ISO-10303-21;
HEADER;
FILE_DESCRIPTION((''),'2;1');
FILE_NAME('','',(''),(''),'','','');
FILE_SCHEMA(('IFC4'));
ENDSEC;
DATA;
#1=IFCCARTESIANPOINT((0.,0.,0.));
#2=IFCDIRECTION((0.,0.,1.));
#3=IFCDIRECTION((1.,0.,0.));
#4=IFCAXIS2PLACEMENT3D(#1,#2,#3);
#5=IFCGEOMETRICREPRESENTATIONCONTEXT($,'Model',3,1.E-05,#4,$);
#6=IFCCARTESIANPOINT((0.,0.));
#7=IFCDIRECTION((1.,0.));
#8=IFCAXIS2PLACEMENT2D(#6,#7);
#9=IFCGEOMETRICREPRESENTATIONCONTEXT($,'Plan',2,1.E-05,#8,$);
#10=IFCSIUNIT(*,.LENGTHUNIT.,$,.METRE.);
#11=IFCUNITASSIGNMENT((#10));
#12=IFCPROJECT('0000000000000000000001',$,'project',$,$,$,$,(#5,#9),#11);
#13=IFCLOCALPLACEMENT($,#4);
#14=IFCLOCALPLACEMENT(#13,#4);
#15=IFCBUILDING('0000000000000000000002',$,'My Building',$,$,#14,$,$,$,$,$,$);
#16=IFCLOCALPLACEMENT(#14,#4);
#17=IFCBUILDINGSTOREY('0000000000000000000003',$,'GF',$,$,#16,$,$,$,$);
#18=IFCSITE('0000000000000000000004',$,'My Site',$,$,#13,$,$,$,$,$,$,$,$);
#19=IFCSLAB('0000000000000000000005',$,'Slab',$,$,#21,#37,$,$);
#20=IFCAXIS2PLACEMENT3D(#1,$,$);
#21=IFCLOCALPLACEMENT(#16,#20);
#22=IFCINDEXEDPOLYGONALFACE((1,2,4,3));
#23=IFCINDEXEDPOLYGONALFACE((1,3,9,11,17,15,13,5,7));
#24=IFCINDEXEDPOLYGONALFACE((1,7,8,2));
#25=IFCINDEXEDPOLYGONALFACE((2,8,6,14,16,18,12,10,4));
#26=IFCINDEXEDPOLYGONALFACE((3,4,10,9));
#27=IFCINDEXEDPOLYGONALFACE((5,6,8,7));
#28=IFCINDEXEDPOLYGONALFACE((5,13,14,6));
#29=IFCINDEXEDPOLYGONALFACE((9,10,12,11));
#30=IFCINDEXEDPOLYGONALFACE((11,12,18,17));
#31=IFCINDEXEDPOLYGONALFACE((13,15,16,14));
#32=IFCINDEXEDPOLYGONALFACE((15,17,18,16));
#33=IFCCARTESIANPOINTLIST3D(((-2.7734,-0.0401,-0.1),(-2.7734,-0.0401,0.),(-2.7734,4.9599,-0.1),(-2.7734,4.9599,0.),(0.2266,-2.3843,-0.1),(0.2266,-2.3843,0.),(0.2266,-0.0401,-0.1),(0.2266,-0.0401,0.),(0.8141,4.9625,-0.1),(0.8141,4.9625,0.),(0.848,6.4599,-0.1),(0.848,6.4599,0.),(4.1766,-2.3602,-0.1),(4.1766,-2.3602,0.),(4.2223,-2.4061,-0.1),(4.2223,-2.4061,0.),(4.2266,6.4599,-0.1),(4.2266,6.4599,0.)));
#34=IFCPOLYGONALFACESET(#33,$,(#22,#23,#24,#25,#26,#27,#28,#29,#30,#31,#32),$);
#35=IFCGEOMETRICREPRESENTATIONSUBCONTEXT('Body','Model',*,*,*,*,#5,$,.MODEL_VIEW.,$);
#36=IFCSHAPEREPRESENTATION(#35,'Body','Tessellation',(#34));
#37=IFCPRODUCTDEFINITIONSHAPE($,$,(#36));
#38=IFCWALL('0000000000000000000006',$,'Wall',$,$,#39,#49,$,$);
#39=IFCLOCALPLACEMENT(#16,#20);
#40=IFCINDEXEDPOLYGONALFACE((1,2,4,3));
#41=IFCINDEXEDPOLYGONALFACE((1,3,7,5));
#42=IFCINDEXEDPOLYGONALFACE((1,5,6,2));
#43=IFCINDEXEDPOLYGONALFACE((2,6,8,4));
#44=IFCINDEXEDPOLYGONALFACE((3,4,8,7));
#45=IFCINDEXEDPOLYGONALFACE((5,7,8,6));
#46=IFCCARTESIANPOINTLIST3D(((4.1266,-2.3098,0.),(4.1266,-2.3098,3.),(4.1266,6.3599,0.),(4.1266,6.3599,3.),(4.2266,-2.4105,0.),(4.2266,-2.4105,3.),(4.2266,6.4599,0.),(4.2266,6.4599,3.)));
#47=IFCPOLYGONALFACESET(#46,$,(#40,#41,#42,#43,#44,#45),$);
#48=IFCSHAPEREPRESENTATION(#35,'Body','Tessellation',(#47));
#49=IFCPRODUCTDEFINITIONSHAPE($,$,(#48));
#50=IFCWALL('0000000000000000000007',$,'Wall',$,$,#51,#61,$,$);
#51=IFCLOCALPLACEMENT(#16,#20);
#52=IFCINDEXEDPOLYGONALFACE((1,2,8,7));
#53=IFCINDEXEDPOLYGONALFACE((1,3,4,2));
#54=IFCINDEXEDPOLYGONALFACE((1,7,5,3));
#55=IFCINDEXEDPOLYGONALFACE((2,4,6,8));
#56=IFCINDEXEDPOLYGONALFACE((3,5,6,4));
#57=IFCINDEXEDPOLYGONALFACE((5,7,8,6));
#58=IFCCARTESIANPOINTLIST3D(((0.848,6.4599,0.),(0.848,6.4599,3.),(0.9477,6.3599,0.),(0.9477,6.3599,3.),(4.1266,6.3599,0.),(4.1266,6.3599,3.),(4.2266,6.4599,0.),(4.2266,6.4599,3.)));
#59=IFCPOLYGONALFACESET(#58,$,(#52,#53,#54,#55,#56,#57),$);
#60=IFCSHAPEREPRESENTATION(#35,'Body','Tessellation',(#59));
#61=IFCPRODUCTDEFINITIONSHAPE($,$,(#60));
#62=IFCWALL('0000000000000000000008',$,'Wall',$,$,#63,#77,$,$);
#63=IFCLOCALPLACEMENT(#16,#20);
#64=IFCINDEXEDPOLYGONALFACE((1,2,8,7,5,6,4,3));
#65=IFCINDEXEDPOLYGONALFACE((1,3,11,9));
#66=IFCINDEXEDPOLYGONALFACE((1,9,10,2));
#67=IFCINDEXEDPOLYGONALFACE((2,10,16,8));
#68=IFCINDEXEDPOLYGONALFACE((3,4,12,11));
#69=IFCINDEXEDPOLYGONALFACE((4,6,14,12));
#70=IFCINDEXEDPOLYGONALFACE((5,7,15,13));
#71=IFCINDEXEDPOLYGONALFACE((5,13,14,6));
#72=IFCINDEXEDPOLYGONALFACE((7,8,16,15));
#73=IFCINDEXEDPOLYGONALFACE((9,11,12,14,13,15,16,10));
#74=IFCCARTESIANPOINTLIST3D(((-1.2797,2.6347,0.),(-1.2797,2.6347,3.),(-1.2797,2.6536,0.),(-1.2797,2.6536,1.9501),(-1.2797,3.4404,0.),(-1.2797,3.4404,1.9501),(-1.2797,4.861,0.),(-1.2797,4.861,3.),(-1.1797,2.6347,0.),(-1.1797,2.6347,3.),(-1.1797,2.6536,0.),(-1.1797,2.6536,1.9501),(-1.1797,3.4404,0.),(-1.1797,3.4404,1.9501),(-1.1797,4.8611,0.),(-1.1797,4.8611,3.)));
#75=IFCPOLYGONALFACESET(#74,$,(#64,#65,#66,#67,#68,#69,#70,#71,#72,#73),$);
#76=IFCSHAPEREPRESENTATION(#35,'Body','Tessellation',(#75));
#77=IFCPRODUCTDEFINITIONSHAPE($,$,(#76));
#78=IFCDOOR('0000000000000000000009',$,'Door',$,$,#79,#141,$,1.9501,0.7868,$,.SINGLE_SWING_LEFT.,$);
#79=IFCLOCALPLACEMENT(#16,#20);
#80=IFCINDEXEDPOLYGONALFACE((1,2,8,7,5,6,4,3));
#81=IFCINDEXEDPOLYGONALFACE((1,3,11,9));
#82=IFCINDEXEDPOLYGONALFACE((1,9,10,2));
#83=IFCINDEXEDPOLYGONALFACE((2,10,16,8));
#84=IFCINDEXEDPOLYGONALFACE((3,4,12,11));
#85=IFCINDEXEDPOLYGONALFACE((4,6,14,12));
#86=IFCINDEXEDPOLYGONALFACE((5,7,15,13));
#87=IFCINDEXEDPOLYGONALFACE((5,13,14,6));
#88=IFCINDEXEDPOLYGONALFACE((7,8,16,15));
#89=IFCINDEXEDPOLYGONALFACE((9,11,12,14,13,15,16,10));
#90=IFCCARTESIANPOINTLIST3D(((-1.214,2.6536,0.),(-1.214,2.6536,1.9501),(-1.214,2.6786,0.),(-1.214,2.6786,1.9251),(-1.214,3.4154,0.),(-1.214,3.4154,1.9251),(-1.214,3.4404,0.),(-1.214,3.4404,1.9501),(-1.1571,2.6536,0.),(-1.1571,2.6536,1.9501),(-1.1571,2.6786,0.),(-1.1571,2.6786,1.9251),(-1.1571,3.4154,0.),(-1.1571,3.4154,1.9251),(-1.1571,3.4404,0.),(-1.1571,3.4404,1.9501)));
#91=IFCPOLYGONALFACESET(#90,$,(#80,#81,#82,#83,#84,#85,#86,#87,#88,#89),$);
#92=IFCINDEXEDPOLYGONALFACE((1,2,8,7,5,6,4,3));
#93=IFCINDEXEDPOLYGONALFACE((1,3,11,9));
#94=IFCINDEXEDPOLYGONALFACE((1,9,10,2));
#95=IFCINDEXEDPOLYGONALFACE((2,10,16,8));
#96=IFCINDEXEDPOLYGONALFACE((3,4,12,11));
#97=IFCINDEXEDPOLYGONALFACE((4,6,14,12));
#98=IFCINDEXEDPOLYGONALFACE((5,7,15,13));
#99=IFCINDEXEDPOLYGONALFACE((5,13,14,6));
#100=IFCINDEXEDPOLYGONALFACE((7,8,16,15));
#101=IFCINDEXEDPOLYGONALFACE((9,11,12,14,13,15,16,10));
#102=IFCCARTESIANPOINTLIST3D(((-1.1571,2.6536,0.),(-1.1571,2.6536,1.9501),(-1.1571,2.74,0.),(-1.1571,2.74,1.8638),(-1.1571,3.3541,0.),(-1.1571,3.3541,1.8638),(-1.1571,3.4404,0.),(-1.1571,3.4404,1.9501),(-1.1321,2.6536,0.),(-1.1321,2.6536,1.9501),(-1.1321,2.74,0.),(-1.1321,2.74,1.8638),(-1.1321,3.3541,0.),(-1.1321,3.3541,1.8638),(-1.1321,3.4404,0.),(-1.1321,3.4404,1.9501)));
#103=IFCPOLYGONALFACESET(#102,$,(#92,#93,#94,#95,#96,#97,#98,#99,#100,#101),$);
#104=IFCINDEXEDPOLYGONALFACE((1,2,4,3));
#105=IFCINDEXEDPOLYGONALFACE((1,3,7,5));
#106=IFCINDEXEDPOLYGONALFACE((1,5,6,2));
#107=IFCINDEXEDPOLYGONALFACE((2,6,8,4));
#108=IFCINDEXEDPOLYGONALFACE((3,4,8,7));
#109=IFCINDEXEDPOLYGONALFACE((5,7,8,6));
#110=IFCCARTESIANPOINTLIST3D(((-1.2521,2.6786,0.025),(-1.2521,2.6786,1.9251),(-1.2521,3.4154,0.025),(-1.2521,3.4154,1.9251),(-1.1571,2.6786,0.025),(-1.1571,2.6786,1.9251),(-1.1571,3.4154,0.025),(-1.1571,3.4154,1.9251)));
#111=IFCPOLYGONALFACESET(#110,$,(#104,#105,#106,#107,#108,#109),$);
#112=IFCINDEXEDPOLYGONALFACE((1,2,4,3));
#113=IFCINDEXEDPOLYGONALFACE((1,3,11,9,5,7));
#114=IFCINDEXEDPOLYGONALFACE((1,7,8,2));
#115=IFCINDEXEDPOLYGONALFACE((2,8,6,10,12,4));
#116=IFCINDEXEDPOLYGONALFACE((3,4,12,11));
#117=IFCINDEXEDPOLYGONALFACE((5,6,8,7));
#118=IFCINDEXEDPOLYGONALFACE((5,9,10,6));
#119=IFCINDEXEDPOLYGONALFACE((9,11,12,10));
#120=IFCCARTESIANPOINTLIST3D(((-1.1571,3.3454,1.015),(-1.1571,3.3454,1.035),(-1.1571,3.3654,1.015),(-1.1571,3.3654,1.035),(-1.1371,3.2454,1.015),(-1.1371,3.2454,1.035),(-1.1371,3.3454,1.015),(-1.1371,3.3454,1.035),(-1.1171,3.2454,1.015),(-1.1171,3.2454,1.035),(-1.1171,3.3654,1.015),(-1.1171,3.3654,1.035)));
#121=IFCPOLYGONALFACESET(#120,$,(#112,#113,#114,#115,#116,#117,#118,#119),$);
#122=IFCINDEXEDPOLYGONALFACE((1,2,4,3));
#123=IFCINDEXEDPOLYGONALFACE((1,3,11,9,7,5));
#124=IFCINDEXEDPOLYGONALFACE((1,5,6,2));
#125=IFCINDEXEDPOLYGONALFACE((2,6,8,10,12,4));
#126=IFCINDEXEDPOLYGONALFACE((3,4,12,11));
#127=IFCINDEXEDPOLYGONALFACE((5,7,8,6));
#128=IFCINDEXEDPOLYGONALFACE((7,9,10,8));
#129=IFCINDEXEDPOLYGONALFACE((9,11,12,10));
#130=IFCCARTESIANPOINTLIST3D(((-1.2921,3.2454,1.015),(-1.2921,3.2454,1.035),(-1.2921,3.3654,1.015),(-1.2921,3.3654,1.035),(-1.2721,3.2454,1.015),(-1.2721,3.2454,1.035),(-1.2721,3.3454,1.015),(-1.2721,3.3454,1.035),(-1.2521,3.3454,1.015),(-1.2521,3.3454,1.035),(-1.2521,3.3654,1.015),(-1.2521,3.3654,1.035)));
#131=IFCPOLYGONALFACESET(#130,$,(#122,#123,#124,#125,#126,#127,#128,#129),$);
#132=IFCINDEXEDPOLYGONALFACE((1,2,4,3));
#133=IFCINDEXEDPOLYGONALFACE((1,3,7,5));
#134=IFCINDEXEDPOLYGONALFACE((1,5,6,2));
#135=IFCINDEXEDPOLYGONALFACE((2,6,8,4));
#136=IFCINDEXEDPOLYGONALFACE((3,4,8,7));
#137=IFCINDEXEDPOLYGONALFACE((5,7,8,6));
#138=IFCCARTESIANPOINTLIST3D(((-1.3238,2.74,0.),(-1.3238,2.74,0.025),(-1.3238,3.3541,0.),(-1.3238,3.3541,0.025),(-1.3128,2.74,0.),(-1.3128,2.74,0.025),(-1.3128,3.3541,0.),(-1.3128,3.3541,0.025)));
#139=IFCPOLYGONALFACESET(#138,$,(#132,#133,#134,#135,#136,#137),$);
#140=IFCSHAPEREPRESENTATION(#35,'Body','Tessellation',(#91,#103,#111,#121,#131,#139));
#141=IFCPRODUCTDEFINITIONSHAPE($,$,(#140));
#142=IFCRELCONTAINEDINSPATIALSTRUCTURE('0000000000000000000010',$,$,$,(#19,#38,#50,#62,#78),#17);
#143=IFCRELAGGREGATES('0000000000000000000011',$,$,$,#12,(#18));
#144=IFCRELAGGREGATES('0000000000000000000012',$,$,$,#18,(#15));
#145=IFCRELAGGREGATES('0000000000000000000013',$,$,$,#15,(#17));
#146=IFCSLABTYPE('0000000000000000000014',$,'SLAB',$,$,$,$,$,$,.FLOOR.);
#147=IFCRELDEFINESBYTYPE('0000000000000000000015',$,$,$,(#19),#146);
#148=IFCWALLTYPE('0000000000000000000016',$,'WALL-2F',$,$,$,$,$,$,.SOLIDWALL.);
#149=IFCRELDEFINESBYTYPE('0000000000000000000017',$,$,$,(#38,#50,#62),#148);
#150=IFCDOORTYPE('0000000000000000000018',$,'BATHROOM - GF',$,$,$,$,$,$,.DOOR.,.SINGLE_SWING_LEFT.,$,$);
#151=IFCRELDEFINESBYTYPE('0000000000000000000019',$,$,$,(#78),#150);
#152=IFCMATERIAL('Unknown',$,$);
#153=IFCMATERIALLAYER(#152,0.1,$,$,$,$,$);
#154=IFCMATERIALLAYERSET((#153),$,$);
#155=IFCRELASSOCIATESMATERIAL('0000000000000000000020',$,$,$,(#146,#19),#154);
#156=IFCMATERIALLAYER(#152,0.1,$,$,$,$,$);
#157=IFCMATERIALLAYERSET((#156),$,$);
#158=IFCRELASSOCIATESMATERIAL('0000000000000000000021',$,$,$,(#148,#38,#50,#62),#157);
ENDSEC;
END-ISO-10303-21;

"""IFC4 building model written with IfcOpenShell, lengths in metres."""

from ifc_helpers import new_model, entity, si_unit, frame, origin_with_axes, origin_2d_with_axis, place, context, subcontext, project, spatial, line, indexed_curve, outline, extrude, shape, source, transform, mapped, material, layer, layer_set, layer_usage, type_object, type_shapes, element, fill, save


model = new_model("IFC4")

# Units and contexts
model_context = context("Model", 3, precision=1e-05, world=origin_with_axes())
plan_context = context("Plan", 2, precision=1e-05, world=origin_2d_with_axis())
body_context_1 = subcontext(model_context, "Body", "Model", "MODEL_VIEW")
body_context_2 = subcontext(plan_context, "Body", "Plan", "PLAN_VIEW")
ifc_project = project(units=[si_unit("LENGTHUNIT", "METRE")], contexts=[model_context, plan_context])

# Site, building, storey
site_placement = place(None, origin_with_axes())
site = spatial("IfcSite", under=ifc_project, at=site_placement, Name="My Site")
building_placement = place(site_placement, origin_with_axes())
building = spatial("IfcBuilding", under=site, at=building_placement, Name="My Building")
storey_placement = place(building_placement, origin_with_axes())
storey = spatial("IfcBuildingStorey", under=building, at=storey_placement, Name="GF")

# Slab
ifc_material = material(Name="Unknown")
ifc_layer_1 = layer(ifc_material, 0.1)
ifc_layer_set_1 = layer_set([ifc_layer_1])
ifc_layer_usage_1 = layer_usage(ifc_layer_set_1, "AXIS3", "POSITIVE", -0.1)
slab_type = type_object("IfcSlabType", Name="SLAB", PredefinedType="FLOOR", material=ifc_layer_set_1)
slab_placement = place(storey_placement, frame((4.2223, -2.4061, 0.0), z_axis=(0.0, 0.0, 1.0), x_axis=(1.0, 0.0, 0.0)))
element("IfcSlab", 1, at=slab_placement, inside=storey, type_object=slab_type, material=ifc_layer_usage_1, Name="Slab", context=body_context_1, shape_type="SweptSolid", body=[
    extrude(outline(indexed_curve([(0.0, 0.0), (0.0043, 8.866), (-3.3742, 8.866), (-3.4082, 7.3687), (-6.9957, 7.366), (-6.9957, 2.366), (-3.9957, 2.366), (-3.9957, 0.0219), (-0.0457, 0.046), (0.0, 0.0)])), frame((0.0, 0.0, -0.1), z_axis=(0.0, 0.0, 1.0), x_axis=(1.0, 0.0, 0.0)), (0.0, 0.0, 1.0), 0.1),
])

# Walls
ifc_layer_2 = layer(ifc_material, 0.1)
ifc_layer_set_2 = layer_set([ifc_layer_2])
ifc_layer_usage_2 = layer_usage(ifc_layer_set_2, "AXIS2", "POSITIVE", 0.0)
wall_type = type_object("IfcWallType", Name="WALL-2F", PredefinedType="SOLIDWALL", material=ifc_layer_set_2)
wall_1_placement = place(storey_placement, frame((4.2266, -2.4105, 0.0), z_axis=(0.0, 0.0, 1.0), x_axis=(0.0, 1.0, 0.0)))
element("IfcWall", 2, at=wall_1_placement, inside=storey, type_object=wall_type, material=ifc_layer_usage_2, Name="Wall", context=body_context_1, shape_type="SweptSolid", body=[
    extrude(outline(indexed_curve([(0.0, 0.0), (0.1007, 0.1), (8.7704, 0.1), (8.8704, 0.0)], segments=[line(1, 2, 3, 4, 1)])), origin_with_axes(), (0.0, 0.0, 1.0), 3.0),
])
ifc_layer_usage_3 = layer_usage(ifc_layer_set_2, "AXIS2", "POSITIVE", 0.0)
wall_2_placement = place(storey_placement, frame((4.2266, 6.4599, 0.0), z_axis=(0.0, 0.0, 1.0), x_axis=(-1.0, 0.0, 0.0)))
element("IfcWall", 3, at=wall_2_placement, inside=storey, type_object=wall_type, material=ifc_layer_usage_3, Name="Wall", context=body_context_1, shape_type="SweptSolid", body=[
    extrude(outline(indexed_curve([(0.0, 0.0), (0.1, 0.1), (3.2789, 0.1), (3.3786, 0.0)], segments=[line(1, 2, 3, 4, 1)])), origin_with_axes(), (0.0, 0.0, 1.0), 3.0),
])

# Wall, opening, door
ifc_layer_usage_4 = layer_usage(ifc_layer_set_2, "AXIS2", "POSITIVE", 0.0)
wall_3_placement = place(storey_placement, frame((-1.1797, 2.6347, 0.0), z_axis=(0.0, 0.0, 1.0), x_axis=(0.0, 1.0, 0.0)))
wall_3 = element("IfcWall", 4, at=wall_3_placement, inside=storey, type_object=wall_type, material=ifc_layer_usage_4, Name="Wall", context=body_context_1, shape_type="SweptSolid", body=[
    extrude(outline(indexed_curve([(0.0, 0.0), (0.0, 0.1), (2.2263, 0.1), (2.2264, 0.0)], segments=[line(1, 2, 3, 4, 1)])), origin_with_axes(), (0.0, 0.0, 1.0), 3.0),
])
shared_shape_1 = source(origin_with_axes(), body_context_1, "Body", "SweptSolid", [
    extrude(outline(indexed_curve([(0.0, 0.0), (0.7868, 0.0), (0.7868, 1.9501), (0.0, 1.9501)], segments=[line(1, 2, 3, 4, 1)])), frame((0.0, -0.6, 0.0), z_axis=(0.0, -1.0, 0.0), x_axis=(1.0, 0.0, 0.0)), (0.0, 0.0, -1.0), 1.2),
])
opening_1_placement = place(wall_3_placement, frame((0.0189, -0.0319, 0.0), z_axis=(0.0, 0.0, 1.0), x_axis=(1.0, 0.0, 0.0)))
opening_1 = element("IfcOpeningElement", 5, at=opening_1_placement, cuts=wall_3, PredefinedType="OPENING", context=body_context_1, shape_type="MappedRepresentation", body=[
    mapped(shared_shape_1, transform((0.0, 0.0, 0.0), x_axis=(1.0, 0.0, 0.0), y_axis=(0.0, 1.0, 0.0), z_axis=(0.0, 0.0, 1.0), scale=1.0)),
])
door_type_1 = type_object("IfcDoorType", Name="BATHROOM - GF", OperationType="SINGLE_SWING_LEFT", PredefinedType="DOOR")
shared_shape_2 = source(origin_with_axes(), body_context_1, "Body", "SweptSolid", [
    extrude(outline(indexed_curve([(0.0, 0.0), (0.0, 1.9501), (0.7868, 1.9501), (0.7868, 0.0), (0.7618, 0.0), (0.7618, 1.9251), (0.025, 1.9251), (0.025, 0.0)], segments=[line(1, 2, 3, 4, 5, 6, 7, 8, 1)])), frame((0.0, 0.0093, 0.0), z_axis=(0.0, -1.0, 0.0), x_axis=(1.0, 0.0, 0.0)), (0.0, 0.0, -1.0), 0.0569),
    extrude(outline(indexed_curve([(0.0, 0.0), (0.0, 1.9501), (0.7868, 1.9501), (0.7868, 0.0), (0.7005, 0.0), (0.7005, 1.8638), (0.0864, 1.8638), (0.0864, 0.0)], segments=[line(1, 2, 3, 4, 5, 6, 7, 8, 1)])), frame((0.0, -0.0157, 0.0), z_axis=(0.0, -1.0, 0.0), x_axis=(1.0, 0.0, 0.0)), (0.0, 0.0, -1.0), 0.025),
    extrude(outline(indexed_curve([(0.0, 0.0), (0.7368, 0.0), (0.7368, 0.095), (0.0, 0.095)], segments=[line(1, 2, 3, 4, 1)])), frame((0.025, 0.0093, 0.025), z_axis=(0.0, 0.0, 1.0), x_axis=(1.0, 0.0, 0.0)), (0.0, 0.0, 1.0), 1.9001),
    extrude(outline(indexed_curve([(0.0, 0.0), (0.0, -0.04), (-0.12, -0.04), (-0.12, -0.02), (-0.02, -0.02), (-0.02, 0.0)], segments=[line(1, 2, 3, 4, 5, 6, 1)])), frame((0.7118, 0.0093, 1.015), z_axis=(0.0, 0.0, 1.0), x_axis=(1.0, 0.0, 0.0)), (0.0, 0.0, 1.0), 0.02),
    extrude(outline(indexed_curve([(0.0, 0.0), (0.0, 0.04), (-0.12, 0.04), (-0.12, 0.02), (-0.02, 0.02), (-0.02, 0.0)], segments=[line(1, 2, 3, 4, 5, 6, 1)])), frame((0.7118, 0.1043, 1.015), z_axis=(0.0, 0.0, 1.0), x_axis=(1.0, 0.0, 0.0)), (0.0, 0.0, 1.0), 0.02),
    extrude(outline(indexed_curve([(0.0, 0.0), (0.6141, 0.0), (0.6141, 0.011), (0.0, 0.011)], segments=[line(1, 2, 3, 4, 1)])), frame((0.0864, 0.165, 0.0), z_axis=(0.0, 0.0, 1.0), x_axis=(1.0, 0.0, 0.0)), (0.0, 0.0, 1.0), 0.025),
])
shared_shape_3 = source(origin_with_axes(), body_context_2, "Body", "Curve2D", [
    entity("IfcIndexedPolyCurve", entity("IfcCartesianPointList2D", [[0.0, -0.0157], [0.0, 0.0662], [0.025, 0.0662], [0.025, 0.0093], [0.0864, 0.0093], [0.0864, -0.0157]]), [entity("IfcLineIndex", [1, 2, 3, 4, 5, 6, 1])]),
    entity("IfcIndexedPolyCurve", entity("IfcCartesianPointList2D", [[0.7868, -0.0157], [0.7868, 0.0662], [0.7618, 0.0662], [0.7618, 0.0093], [0.7005, 0.0093], [0.7005, -0.0157]]), [entity("IfcLineIndex", [1, 2, 3, 4, 5, 6, 1])]),
    entity("IfcTrimmedCurve", entity("IfcEllipse", entity("IfcAxis2Placement2D", entity("IfcCartesianPoint", [0.12, 0.0662]), entity("IfcDirection", [1.0, 0.0])), 0.6418, 0.7368), [entity("IfcCartesianPoint", [0.7618, 0.0662])], [entity("IfcCartesianPoint", [0.12, 0.803])], True, "CARTESIAN"),
    entity("IfcIndexedPolyCurve", entity("IfcCartesianPointList2D", [[0.025, 0.0662], [0.12, 0.0662], [0.12, 0.803], [0.025, 0.803]]), [entity("IfcLineIndex", [1, 2, 3, 4, 1])]),
])
type_shapes(door_type_1, [shared_shape_2, shared_shape_3])
door_1_placement = place(opening_1_placement, frame((0.0, 0.0, 0.0), z_axis=(0.0, 0.0, 1.0), x_axis=(1.0, 0.0, 0.0)))
door_1 = element("IfcDoor", 6, at=door_1_placement, inside=storey, type_object=door_type_1, Name="Door", OperationType="SINGLE_SWING_LEFT", OverallHeight=1.9501, OverallWidth=0.7868, shapes=[
    shape(body_context_1, "Body", "MappedRepresentation", [mapped(shared_shape_2, transform((0.0, 0.0, 0.0), x_axis=(1.0, 0.0, 0.0), y_axis=(0.0, 1.0, 0.0), z_axis=(0.0, 0.0, 1.0), scale=1.0))]),
    shape(body_context_2, "Body", "MappedRepresentation", [mapped(shared_shape_3, transform((0.0, 0.0, 0.0), x_axis=(1.0, 0.0, 0.0), y_axis=(0.0, 1.0, 0.0), z_axis=(0.0, 0.0, 1.0), scale=1.0))]),
])
fill(opening_1, door_1)

save(model, "model.ifc")
